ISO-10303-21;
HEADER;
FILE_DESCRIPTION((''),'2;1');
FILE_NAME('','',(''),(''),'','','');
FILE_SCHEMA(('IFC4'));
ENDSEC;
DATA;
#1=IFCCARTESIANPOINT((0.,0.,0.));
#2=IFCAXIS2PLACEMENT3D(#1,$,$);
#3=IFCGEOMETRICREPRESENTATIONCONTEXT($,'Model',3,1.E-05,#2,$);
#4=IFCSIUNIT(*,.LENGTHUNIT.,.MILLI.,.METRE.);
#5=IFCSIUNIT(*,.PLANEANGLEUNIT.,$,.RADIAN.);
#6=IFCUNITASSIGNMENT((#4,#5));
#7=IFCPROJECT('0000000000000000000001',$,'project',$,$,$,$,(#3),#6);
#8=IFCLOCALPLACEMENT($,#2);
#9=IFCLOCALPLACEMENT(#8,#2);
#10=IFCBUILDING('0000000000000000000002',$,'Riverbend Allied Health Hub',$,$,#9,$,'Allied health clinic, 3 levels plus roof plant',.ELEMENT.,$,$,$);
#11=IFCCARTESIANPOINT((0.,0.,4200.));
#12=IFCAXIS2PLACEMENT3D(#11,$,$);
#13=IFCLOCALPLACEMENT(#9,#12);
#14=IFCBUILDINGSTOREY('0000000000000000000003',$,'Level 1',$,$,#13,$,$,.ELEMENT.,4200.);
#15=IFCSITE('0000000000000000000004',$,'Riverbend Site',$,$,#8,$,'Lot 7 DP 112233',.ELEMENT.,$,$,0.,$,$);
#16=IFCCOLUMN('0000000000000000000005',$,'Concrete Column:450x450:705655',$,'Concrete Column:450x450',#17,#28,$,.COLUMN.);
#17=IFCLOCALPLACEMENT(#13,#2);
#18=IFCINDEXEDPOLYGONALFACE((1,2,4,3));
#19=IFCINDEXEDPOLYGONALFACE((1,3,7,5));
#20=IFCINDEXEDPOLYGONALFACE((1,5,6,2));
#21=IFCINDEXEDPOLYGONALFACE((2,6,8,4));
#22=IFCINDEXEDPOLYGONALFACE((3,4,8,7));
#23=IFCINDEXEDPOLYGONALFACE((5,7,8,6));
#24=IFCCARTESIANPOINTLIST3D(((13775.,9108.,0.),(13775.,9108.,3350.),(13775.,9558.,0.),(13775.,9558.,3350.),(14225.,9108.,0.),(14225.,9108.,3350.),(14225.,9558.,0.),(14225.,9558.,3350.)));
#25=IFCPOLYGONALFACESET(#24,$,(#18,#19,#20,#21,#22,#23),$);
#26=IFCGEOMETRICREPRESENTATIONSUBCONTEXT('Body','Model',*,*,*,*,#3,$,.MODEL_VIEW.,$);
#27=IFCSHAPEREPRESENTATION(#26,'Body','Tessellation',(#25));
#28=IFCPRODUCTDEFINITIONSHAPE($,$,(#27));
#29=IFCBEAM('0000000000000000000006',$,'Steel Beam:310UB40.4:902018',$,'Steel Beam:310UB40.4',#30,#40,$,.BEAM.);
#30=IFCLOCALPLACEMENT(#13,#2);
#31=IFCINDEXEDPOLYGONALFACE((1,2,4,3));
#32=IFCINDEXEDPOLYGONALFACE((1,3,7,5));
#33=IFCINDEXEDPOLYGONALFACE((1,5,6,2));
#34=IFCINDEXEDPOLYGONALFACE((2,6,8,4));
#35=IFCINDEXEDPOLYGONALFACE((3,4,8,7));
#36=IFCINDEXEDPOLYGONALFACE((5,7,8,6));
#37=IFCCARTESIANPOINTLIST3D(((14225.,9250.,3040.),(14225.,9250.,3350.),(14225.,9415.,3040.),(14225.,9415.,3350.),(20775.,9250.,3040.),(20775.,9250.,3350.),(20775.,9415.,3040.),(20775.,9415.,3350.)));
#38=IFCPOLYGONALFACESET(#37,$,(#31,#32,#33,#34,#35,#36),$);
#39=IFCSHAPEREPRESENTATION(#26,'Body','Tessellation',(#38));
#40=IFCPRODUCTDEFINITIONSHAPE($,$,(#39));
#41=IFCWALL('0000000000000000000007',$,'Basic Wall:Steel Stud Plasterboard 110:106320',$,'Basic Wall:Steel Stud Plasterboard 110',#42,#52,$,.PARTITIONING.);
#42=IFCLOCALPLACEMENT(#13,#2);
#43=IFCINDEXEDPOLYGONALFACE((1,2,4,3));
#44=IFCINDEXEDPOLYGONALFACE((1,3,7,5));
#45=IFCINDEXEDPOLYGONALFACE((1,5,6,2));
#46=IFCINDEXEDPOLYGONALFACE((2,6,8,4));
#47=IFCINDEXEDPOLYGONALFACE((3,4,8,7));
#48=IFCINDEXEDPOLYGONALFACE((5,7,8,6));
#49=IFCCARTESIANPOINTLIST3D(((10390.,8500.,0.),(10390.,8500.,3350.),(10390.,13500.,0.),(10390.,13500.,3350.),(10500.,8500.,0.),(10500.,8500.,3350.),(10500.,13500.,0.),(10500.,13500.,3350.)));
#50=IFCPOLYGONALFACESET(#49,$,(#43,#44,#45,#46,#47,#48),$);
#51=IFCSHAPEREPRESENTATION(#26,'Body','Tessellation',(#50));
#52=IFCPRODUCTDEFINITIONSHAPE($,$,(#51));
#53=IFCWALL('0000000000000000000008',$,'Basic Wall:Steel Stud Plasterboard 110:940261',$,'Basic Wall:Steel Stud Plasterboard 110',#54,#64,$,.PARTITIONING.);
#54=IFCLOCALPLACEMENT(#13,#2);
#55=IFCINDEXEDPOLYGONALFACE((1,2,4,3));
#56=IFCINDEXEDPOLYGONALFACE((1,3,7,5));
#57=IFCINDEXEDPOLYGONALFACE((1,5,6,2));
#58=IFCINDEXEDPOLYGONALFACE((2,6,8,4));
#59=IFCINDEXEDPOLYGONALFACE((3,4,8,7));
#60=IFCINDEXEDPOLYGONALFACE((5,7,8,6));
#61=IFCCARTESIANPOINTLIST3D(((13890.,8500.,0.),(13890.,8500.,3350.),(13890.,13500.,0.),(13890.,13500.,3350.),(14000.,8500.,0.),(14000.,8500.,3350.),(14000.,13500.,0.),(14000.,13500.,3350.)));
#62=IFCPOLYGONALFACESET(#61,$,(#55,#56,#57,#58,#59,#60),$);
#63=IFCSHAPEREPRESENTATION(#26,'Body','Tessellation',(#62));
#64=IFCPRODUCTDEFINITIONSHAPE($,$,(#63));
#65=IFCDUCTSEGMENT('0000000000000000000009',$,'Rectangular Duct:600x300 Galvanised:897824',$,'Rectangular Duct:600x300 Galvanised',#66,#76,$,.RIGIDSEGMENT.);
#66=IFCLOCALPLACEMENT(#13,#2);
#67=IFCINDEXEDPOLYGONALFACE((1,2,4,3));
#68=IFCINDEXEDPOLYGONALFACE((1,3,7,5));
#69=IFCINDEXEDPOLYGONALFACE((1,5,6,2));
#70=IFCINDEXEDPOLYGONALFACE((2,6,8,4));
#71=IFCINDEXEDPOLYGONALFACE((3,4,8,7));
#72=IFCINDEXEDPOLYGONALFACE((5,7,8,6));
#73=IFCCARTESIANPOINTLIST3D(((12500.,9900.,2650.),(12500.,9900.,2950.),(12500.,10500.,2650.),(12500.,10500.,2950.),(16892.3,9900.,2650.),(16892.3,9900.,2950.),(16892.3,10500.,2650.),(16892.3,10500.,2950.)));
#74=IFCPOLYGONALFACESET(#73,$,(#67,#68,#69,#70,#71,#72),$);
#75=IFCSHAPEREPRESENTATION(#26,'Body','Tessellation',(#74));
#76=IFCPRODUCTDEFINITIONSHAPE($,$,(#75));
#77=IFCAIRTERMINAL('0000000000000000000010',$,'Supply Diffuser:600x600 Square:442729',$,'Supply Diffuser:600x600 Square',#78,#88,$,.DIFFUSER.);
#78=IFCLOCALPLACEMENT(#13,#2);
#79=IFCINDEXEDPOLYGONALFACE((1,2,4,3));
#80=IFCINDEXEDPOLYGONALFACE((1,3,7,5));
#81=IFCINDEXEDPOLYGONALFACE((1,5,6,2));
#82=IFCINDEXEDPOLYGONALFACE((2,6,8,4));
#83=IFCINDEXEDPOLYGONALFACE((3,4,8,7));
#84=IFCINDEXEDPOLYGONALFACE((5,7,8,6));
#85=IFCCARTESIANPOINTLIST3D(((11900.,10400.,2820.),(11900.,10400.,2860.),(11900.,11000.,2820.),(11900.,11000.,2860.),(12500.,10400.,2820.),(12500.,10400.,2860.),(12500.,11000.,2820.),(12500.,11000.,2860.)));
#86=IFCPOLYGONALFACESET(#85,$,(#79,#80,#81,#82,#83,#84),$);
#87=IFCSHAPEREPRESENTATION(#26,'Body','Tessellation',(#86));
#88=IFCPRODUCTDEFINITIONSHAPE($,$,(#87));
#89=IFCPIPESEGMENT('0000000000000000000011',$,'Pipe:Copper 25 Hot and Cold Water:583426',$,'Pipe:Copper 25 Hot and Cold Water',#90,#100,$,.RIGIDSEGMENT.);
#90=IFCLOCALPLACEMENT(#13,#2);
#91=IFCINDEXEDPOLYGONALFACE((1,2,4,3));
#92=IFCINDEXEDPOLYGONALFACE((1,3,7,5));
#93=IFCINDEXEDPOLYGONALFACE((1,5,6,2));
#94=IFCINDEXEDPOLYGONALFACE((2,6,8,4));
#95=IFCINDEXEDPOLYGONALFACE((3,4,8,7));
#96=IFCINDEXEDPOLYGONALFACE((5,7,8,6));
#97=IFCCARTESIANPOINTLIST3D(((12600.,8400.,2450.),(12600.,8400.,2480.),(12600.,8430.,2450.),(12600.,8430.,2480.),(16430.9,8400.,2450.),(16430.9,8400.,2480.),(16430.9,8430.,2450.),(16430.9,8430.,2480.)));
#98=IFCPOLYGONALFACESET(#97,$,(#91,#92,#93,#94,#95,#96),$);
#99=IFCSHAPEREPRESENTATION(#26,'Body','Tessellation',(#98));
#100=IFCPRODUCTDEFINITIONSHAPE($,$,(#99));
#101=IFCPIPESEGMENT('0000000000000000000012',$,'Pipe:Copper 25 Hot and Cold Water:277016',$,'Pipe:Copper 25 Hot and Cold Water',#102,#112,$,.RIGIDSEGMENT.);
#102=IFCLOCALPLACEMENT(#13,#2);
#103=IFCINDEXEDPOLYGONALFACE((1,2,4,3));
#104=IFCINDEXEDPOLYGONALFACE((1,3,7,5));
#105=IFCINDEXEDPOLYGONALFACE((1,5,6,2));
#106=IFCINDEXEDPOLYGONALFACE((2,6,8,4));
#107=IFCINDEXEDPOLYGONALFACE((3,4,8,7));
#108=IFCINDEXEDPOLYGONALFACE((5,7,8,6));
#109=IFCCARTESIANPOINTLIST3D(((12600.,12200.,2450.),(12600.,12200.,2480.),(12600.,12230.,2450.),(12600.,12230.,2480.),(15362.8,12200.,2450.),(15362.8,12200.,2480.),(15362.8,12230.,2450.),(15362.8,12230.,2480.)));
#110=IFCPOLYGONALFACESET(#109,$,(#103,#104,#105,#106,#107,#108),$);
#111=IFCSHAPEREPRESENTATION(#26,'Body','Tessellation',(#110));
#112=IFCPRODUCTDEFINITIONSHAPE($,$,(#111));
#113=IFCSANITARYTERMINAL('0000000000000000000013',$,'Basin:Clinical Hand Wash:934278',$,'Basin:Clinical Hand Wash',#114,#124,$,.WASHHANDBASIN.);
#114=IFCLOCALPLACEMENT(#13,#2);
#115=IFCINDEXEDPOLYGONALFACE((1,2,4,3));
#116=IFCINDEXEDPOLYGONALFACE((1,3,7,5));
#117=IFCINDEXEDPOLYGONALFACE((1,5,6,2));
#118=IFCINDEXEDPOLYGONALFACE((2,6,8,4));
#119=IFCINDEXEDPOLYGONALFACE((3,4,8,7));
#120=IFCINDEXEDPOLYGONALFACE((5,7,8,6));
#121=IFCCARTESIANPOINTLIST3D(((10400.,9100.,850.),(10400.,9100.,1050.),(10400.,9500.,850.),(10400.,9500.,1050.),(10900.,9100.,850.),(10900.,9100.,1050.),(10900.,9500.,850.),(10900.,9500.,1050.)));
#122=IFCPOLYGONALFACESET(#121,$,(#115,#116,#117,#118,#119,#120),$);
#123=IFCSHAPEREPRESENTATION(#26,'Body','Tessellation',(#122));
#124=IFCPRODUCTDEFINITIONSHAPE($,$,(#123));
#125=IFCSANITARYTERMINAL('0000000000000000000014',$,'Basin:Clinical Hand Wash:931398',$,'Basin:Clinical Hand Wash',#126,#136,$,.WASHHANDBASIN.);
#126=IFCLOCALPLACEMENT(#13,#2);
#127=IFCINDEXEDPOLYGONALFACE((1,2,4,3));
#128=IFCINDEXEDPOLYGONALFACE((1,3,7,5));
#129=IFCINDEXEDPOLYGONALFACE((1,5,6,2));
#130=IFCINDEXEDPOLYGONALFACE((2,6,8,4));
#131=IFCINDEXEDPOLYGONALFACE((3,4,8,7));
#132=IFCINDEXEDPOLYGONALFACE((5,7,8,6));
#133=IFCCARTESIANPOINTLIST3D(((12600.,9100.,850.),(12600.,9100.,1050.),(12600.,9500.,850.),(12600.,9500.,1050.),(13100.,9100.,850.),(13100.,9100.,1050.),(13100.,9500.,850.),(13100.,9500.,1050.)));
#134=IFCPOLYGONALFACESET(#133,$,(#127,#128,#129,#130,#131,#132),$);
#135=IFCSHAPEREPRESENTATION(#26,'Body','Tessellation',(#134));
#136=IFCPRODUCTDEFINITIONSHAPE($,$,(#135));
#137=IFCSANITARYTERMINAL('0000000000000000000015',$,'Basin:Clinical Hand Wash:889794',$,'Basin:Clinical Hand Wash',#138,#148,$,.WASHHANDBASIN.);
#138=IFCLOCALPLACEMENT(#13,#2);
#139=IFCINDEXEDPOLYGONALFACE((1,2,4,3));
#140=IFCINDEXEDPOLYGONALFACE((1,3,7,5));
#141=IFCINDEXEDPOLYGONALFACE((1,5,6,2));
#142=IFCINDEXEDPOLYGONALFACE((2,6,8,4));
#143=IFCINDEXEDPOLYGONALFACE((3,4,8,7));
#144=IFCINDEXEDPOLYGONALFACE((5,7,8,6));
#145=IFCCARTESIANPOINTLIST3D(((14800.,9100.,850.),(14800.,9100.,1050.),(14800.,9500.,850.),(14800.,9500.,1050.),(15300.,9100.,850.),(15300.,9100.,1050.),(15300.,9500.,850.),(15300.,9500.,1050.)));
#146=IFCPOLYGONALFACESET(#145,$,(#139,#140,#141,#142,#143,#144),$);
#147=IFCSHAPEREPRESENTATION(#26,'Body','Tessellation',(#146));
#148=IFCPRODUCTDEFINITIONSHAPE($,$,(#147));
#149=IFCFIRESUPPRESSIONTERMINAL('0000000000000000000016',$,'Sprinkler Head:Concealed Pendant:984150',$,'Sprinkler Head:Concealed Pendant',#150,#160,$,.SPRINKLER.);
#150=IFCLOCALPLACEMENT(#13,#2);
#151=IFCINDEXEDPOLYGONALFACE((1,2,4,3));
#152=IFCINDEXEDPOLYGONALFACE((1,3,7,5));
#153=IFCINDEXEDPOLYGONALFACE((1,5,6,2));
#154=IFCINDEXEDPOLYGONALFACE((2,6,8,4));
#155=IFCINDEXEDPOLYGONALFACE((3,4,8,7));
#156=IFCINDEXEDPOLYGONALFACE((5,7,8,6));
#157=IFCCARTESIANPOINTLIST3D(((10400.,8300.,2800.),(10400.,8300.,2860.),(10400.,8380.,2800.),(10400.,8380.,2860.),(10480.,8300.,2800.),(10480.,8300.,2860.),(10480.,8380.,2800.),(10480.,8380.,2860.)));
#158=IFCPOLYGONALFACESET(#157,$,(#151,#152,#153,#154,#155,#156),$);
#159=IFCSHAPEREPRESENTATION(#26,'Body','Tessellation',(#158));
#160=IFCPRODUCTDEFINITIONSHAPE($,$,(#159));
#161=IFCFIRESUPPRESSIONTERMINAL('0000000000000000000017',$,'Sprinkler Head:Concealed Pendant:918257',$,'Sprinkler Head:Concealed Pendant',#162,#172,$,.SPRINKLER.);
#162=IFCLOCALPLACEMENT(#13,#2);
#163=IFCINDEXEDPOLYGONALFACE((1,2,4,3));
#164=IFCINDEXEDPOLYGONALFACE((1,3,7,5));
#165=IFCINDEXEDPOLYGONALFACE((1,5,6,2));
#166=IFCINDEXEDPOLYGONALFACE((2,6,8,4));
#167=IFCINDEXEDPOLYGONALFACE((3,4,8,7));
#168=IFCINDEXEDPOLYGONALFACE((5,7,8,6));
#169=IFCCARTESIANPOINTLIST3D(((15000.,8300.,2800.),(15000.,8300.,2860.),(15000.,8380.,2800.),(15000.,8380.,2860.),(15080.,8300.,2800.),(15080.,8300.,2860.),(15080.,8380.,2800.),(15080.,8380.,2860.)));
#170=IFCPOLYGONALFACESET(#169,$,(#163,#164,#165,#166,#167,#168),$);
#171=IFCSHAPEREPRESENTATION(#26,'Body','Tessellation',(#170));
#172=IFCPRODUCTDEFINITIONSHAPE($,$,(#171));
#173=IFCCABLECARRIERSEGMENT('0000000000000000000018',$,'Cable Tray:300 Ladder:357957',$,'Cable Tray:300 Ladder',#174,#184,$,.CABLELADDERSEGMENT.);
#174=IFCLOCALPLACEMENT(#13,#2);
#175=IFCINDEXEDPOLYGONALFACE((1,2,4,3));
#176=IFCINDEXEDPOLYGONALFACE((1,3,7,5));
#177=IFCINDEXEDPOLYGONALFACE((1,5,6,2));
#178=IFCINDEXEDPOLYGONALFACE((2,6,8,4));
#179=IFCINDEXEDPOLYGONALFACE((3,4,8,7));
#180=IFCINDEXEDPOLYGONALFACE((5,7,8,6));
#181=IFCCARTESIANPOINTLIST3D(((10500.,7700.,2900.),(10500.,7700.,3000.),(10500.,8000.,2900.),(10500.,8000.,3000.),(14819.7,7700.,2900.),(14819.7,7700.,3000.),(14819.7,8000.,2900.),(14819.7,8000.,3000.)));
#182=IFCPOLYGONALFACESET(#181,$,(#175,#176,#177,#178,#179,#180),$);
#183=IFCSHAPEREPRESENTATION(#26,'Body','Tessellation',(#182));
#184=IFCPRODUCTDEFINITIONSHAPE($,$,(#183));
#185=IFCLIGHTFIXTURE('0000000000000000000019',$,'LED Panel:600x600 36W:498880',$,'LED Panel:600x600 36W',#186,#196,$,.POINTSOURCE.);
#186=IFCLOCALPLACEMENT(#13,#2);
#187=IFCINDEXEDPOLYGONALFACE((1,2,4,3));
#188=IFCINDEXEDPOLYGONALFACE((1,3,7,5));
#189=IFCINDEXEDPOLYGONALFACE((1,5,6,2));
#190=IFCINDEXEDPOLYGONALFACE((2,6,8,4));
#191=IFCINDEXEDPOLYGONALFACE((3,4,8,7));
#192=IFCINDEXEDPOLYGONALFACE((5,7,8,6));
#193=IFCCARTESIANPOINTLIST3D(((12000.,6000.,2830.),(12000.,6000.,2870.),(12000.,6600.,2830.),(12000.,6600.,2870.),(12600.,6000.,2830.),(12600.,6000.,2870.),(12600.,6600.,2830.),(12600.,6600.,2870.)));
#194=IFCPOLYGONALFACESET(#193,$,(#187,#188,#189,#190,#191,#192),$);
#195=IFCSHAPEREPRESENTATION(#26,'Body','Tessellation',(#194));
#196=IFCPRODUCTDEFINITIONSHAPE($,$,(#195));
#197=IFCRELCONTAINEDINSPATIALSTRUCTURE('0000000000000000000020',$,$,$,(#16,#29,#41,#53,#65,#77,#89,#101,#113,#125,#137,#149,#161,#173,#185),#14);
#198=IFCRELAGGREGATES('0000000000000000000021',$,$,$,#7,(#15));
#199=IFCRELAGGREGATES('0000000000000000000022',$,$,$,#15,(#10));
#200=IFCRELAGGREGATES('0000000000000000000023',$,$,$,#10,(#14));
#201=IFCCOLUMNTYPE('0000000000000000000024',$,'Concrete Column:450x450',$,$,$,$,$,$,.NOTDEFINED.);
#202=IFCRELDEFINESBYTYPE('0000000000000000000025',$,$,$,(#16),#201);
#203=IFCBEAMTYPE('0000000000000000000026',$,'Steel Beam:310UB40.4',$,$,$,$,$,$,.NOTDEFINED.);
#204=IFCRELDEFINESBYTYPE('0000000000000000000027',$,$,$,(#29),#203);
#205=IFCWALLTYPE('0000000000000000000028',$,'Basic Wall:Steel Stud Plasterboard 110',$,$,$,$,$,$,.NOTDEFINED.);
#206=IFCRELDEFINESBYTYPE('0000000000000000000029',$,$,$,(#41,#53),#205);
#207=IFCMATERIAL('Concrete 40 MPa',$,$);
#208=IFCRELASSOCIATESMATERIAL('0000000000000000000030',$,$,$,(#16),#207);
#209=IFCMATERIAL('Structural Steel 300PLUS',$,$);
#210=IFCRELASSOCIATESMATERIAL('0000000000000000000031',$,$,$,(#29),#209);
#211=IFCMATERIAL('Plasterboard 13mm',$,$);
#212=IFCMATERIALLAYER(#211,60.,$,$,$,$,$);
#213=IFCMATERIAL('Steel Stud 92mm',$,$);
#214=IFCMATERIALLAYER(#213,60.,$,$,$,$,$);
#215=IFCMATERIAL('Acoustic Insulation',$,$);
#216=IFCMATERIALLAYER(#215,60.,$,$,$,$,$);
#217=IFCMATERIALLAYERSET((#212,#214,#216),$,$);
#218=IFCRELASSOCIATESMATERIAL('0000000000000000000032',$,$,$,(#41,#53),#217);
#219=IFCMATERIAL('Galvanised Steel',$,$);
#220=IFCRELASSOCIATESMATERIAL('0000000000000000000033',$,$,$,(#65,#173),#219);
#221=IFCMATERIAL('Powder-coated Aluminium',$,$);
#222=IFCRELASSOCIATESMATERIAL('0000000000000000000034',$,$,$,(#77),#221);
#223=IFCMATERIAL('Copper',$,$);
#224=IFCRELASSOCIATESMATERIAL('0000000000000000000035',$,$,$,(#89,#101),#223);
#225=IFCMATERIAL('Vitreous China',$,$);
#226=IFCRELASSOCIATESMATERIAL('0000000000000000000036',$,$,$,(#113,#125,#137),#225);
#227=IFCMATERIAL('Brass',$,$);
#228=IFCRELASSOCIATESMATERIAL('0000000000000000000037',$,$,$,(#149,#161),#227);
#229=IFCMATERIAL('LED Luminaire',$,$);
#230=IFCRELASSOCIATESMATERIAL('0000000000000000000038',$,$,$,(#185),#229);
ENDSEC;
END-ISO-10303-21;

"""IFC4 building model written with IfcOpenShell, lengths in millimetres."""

from ifc_helpers import new_model, si_unit, frame, frame_2d, origin, place, context, subcontext, project, spatial, rectangle, extrude, material, layer, layer_set, layer_usage, type_object, element, save


model = new_model("IFC4")

# Units and contexts
model_context = context("Model", 3, precision=1e-05, world=origin())
body_context = subcontext(model_context, "Body", "Model", "MODEL_VIEW")
ifc_project = project(units=[si_unit("LENGTHUNIT", "METRE", prefix="MILLI"), si_unit("PLANEANGLEUNIT", "RADIAN")], contexts=[model_context])

# Site, building, storey
site_placement = place(None, origin())
site = spatial("IfcSite", under=ifc_project, at=site_placement, Name="Riverbend Site", LongName="Lot 7 DP 112233", CompositionType="ELEMENT", RefElevation=0.0)
building_placement = place(site_placement, origin())
building = spatial("IfcBuilding", under=site, at=building_placement, Name="Riverbend Allied Health Hub", LongName="Allied health clinic, 3 levels plus roof plant", CompositionType="ELEMENT")
storey_placement = place(building_placement, frame((0.0, 0.0, 4200.0)))
storey = spatial("IfcBuildingStorey", under=building, at=storey_placement, Name="Level 1", CompositionType="ELEMENT", Elevation=4200.0)

# Column
ifc_material_1 = material(Name="Concrete 40 MPa")
column_type = type_object("IfcColumnType", Name="Concrete Column:450x450", PredefinedType="NOTDEFINED")
column_placement = place(storey_placement, frame((13775.0, 9108.0, 0.0)))
element("IfcColumn", 1, at=column_placement, inside=storey, type_object=column_type, material=ifc_material_1, Name="Concrete Column:450x450:705655", ObjectType="Concrete Column:450x450", PredefinedType="COLUMN", context=body_context, shape_type="SweptSolid", body=[
    extrude(rectangle(XDim=450.0, YDim=450.0, at=frame_2d((225.0, 225.0))), origin(), (0.0, 0.0, 1.0), 3350.0),
])

# Beam
ifc_material_2 = material(Name="Structural Steel 300PLUS")
beam_type = type_object("IfcBeamType", Name="Steel Beam:310UB40.4", PredefinedType="NOTDEFINED")
beam_placement = place(storey_placement, frame((14225.0, 9250.0, 3040.0)))
element("IfcBeam", 2, at=beam_placement, inside=storey, type_object=beam_type, material=ifc_material_2, Name="Steel Beam:310UB40.4:902018", ObjectType="Steel Beam:310UB40.4", PredefinedType="BEAM", context=body_context, shape_type="SweptSolid", body=[
    extrude(rectangle(XDim=6550.0, YDim=165.0, at=frame_2d((3275.0, 82.5))), origin(), (0.0, 0.0, 1.0), 310.0),
])

# Walls
ifc_material_3 = material(Name="Plasterboard 13mm")
ifc_layer_1 = layer(ifc_material_3, 60.0)
ifc_material_4 = material(Name="Steel Stud 92mm")
ifc_layer_2 = layer(ifc_material_4, 60.0)
ifc_material_5 = material(Name="Acoustic Insulation")
ifc_layer_3 = layer(ifc_material_5, 60.0)
ifc_layer_set = layer_set([ifc_layer_1, ifc_layer_2, ifc_layer_3])
ifc_layer_usage = layer_usage(ifc_layer_set, "AXIS2", "POSITIVE", 0.0)
wall_type = type_object("IfcWallType", Name="Basic Wall:Steel Stud Plasterboard 110", PredefinedType="NOTDEFINED")
for number, where, z_axis, x_axis, name in (
    (3, (10500.0, 8500.0, 0.0), (0.0, 0.0, 1.0), (0.0, 1.0, 0.0), "Basic Wall:Steel Stud Plasterboard 110:106320"),
    (4, (14000.0, 8500.0, 0.0), (0.0, 0.0, 1.0), (0.0, 1.0, 0.0), "Basic Wall:Steel Stud Plasterboard 110:940261"),
):
    element("IfcWall", number, at=place(storey_placement, frame(where, z_axis=z_axis, x_axis=x_axis)), inside=storey, type_object=wall_type, material=ifc_layer_usage, Name=name, ObjectType="Basic Wall:Steel Stud Plasterboard 110", PredefinedType="PARTITIONING", context=body_context, shape_type="SweptSolid", body=[
        extrude(rectangle(XDim=5000.0, YDim=110.0, at=frame_2d((2500.0, 55.0))), origin(), (0.0, 0.0, 1.0), 3350.0),
    ])

# Duct segment
ifc_material_6 = material(Name="Galvanised Steel")
duct_segment_placement = place(storey_placement, frame((12500.0, 9900.0, 2650.0)))
element("IfcDuctSegment", 5, at=duct_segment_placement, inside=storey, material=ifc_material_6, Name="Rectangular Duct:600x300 Galvanised:897824", ObjectType="Rectangular Duct:600x300 Galvanised", PredefinedType="RIGIDSEGMENT", context=body_context, shape_type="SweptSolid", body=[
    extrude(rectangle(XDim=4392.3, YDim=600.0, at=frame_2d((2196.2, 300.0))), origin(), (0.0, 0.0, 1.0), 300.0),
])

# Air terminal
ifc_material_7 = material(Name="Powder-coated Aluminium")
air_terminal_placement = place(storey_placement, frame((11900.0, 10400.0, 2820.0)))
element("IfcAirTerminal", 6, at=air_terminal_placement, inside=storey, material=ifc_material_7, Name="Supply Diffuser:600x600 Square:442729", ObjectType="Supply Diffuser:600x600 Square", PredefinedType="DIFFUSER", context=body_context, shape_type="SweptSolid", body=[
    extrude(rectangle(XDim=600.0, YDim=600.0, at=frame_2d((300.0, 300.0))), origin(), (0.0, 0.0, 1.0), 40.0),
])

# Pipe segments
ifc_material_8 = material(Name="Copper")
pipe_segment_1_placement = place(storey_placement, frame((12600.0, 8400.0, 2450.0)))
element("IfcPipeSegment", 7, at=pipe_segment_1_placement, inside=storey, material=ifc_material_8, Name="Pipe:Copper 25 Hot and Cold Water:583426", ObjectType="Pipe:Copper 25 Hot and Cold Water", PredefinedType="RIGIDSEGMENT", context=body_context, shape_type="SweptSolid", body=[
    extrude(rectangle(XDim=3830.9, YDim=30.0, at=frame_2d((1915.5, 15.0))), origin(), (0.0, 0.0, 1.0), 30.0),
])
pipe_segment_2_placement = place(storey_placement, frame((12600.0, 12200.0, 2450.0)))
element("IfcPipeSegment", 8, at=pipe_segment_2_placement, inside=storey, material=ifc_material_8, Name="Pipe:Copper 25 Hot and Cold Water:277016", ObjectType="Pipe:Copper 25 Hot and Cold Water", PredefinedType="RIGIDSEGMENT", context=body_context, shape_type="SweptSolid", body=[
    extrude(rectangle(XDim=2762.8, YDim=30.0, at=frame_2d((1381.4, 15.0))), origin(), (0.0, 0.0, 1.0), 30.0),
])

# Sanitary terminals
ifc_material_9 = material(Name="Vitreous China")
for number, where, name in (
    (9, (10400.0, 9100.0, 850.0), "Basin:Clinical Hand Wash:934278"),
    (10, (12600.0, 9100.0, 850.0), "Basin:Clinical Hand Wash:931398"),
    (11, (14800.0, 9100.0, 850.0), "Basin:Clinical Hand Wash:889794"),
):
    element("IfcSanitaryTerminal", number, at=place(storey_placement, frame(where)), inside=storey, material=ifc_material_9, Name=name, ObjectType="Basin:Clinical Hand Wash", PredefinedType="WASHHANDBASIN", context=body_context, shape_type="SweptSolid", body=[
        extrude(rectangle(XDim=500.0, YDim=400.0, at=frame_2d((250.0, 200.0))), origin(), (0.0, 0.0, 1.0), 200.0),
    ])

# Fire suppression terminals
ifc_material_10 = material(Name="Brass")
for number, where, name in (
    (12, (10400.0, 8300.0, 2800.0), "Sprinkler Head:Concealed Pendant:984150"),
    (13, (15000.0, 8300.0, 2800.0), "Sprinkler Head:Concealed Pendant:918257"),
):
    element("IfcFireSuppressionTerminal", number, at=place(storey_placement, frame(where)), inside=storey, material=ifc_material_10, Name=name, ObjectType="Sprinkler Head:Concealed Pendant", PredefinedType="SPRINKLER", context=body_context, shape_type="SweptSolid", body=[
        extrude(rectangle(XDim=80.0, YDim=80.0, at=frame_2d((40.0, 40.0))), origin(), (0.0, 0.0, 1.0), 60.0),
    ])

# Cable carrier segment
cable_carrier_segment_placement = place(storey_placement, frame((10500.0, 7700.0, 2900.0)))
element("IfcCableCarrierSegment", 14, at=cable_carrier_segment_placement, inside=storey, material=ifc_material_6, Name="Cable Tray:300 Ladder:357957", ObjectType="Cable Tray:300 Ladder", PredefinedType="CABLELADDERSEGMENT", context=body_context, shape_type="SweptSolid", body=[
    extrude(rectangle(XDim=4319.7, YDim=300.0, at=frame_2d((2159.8, 150.0))), origin(), (0.0, 0.0, 1.0), 100.0),
])

# Light fixture
ifc_material_11 = material(Name="LED Luminaire")
for number, where, name in (
    (15, (12000.0, 6000.0, 2830.0), "LED Panel:600x600 36W:498880"),
):
    element("IfcLightFixture", number, at=place(storey_placement, frame(where)), inside=storey, material=ifc_material_11, Name=name, ObjectType="LED Panel:600x600 36W", PredefinedType="POINTSOURCE", context=body_context, shape_type="SweptSolid", body=[
        extrude(rectangle(XDim=600.0, YDim=600.0, at=frame_2d((300.0, 300.0))), origin(), (0.0, 0.0, 1.0), 40.0),
    ])

save(model, "model.ifc")
